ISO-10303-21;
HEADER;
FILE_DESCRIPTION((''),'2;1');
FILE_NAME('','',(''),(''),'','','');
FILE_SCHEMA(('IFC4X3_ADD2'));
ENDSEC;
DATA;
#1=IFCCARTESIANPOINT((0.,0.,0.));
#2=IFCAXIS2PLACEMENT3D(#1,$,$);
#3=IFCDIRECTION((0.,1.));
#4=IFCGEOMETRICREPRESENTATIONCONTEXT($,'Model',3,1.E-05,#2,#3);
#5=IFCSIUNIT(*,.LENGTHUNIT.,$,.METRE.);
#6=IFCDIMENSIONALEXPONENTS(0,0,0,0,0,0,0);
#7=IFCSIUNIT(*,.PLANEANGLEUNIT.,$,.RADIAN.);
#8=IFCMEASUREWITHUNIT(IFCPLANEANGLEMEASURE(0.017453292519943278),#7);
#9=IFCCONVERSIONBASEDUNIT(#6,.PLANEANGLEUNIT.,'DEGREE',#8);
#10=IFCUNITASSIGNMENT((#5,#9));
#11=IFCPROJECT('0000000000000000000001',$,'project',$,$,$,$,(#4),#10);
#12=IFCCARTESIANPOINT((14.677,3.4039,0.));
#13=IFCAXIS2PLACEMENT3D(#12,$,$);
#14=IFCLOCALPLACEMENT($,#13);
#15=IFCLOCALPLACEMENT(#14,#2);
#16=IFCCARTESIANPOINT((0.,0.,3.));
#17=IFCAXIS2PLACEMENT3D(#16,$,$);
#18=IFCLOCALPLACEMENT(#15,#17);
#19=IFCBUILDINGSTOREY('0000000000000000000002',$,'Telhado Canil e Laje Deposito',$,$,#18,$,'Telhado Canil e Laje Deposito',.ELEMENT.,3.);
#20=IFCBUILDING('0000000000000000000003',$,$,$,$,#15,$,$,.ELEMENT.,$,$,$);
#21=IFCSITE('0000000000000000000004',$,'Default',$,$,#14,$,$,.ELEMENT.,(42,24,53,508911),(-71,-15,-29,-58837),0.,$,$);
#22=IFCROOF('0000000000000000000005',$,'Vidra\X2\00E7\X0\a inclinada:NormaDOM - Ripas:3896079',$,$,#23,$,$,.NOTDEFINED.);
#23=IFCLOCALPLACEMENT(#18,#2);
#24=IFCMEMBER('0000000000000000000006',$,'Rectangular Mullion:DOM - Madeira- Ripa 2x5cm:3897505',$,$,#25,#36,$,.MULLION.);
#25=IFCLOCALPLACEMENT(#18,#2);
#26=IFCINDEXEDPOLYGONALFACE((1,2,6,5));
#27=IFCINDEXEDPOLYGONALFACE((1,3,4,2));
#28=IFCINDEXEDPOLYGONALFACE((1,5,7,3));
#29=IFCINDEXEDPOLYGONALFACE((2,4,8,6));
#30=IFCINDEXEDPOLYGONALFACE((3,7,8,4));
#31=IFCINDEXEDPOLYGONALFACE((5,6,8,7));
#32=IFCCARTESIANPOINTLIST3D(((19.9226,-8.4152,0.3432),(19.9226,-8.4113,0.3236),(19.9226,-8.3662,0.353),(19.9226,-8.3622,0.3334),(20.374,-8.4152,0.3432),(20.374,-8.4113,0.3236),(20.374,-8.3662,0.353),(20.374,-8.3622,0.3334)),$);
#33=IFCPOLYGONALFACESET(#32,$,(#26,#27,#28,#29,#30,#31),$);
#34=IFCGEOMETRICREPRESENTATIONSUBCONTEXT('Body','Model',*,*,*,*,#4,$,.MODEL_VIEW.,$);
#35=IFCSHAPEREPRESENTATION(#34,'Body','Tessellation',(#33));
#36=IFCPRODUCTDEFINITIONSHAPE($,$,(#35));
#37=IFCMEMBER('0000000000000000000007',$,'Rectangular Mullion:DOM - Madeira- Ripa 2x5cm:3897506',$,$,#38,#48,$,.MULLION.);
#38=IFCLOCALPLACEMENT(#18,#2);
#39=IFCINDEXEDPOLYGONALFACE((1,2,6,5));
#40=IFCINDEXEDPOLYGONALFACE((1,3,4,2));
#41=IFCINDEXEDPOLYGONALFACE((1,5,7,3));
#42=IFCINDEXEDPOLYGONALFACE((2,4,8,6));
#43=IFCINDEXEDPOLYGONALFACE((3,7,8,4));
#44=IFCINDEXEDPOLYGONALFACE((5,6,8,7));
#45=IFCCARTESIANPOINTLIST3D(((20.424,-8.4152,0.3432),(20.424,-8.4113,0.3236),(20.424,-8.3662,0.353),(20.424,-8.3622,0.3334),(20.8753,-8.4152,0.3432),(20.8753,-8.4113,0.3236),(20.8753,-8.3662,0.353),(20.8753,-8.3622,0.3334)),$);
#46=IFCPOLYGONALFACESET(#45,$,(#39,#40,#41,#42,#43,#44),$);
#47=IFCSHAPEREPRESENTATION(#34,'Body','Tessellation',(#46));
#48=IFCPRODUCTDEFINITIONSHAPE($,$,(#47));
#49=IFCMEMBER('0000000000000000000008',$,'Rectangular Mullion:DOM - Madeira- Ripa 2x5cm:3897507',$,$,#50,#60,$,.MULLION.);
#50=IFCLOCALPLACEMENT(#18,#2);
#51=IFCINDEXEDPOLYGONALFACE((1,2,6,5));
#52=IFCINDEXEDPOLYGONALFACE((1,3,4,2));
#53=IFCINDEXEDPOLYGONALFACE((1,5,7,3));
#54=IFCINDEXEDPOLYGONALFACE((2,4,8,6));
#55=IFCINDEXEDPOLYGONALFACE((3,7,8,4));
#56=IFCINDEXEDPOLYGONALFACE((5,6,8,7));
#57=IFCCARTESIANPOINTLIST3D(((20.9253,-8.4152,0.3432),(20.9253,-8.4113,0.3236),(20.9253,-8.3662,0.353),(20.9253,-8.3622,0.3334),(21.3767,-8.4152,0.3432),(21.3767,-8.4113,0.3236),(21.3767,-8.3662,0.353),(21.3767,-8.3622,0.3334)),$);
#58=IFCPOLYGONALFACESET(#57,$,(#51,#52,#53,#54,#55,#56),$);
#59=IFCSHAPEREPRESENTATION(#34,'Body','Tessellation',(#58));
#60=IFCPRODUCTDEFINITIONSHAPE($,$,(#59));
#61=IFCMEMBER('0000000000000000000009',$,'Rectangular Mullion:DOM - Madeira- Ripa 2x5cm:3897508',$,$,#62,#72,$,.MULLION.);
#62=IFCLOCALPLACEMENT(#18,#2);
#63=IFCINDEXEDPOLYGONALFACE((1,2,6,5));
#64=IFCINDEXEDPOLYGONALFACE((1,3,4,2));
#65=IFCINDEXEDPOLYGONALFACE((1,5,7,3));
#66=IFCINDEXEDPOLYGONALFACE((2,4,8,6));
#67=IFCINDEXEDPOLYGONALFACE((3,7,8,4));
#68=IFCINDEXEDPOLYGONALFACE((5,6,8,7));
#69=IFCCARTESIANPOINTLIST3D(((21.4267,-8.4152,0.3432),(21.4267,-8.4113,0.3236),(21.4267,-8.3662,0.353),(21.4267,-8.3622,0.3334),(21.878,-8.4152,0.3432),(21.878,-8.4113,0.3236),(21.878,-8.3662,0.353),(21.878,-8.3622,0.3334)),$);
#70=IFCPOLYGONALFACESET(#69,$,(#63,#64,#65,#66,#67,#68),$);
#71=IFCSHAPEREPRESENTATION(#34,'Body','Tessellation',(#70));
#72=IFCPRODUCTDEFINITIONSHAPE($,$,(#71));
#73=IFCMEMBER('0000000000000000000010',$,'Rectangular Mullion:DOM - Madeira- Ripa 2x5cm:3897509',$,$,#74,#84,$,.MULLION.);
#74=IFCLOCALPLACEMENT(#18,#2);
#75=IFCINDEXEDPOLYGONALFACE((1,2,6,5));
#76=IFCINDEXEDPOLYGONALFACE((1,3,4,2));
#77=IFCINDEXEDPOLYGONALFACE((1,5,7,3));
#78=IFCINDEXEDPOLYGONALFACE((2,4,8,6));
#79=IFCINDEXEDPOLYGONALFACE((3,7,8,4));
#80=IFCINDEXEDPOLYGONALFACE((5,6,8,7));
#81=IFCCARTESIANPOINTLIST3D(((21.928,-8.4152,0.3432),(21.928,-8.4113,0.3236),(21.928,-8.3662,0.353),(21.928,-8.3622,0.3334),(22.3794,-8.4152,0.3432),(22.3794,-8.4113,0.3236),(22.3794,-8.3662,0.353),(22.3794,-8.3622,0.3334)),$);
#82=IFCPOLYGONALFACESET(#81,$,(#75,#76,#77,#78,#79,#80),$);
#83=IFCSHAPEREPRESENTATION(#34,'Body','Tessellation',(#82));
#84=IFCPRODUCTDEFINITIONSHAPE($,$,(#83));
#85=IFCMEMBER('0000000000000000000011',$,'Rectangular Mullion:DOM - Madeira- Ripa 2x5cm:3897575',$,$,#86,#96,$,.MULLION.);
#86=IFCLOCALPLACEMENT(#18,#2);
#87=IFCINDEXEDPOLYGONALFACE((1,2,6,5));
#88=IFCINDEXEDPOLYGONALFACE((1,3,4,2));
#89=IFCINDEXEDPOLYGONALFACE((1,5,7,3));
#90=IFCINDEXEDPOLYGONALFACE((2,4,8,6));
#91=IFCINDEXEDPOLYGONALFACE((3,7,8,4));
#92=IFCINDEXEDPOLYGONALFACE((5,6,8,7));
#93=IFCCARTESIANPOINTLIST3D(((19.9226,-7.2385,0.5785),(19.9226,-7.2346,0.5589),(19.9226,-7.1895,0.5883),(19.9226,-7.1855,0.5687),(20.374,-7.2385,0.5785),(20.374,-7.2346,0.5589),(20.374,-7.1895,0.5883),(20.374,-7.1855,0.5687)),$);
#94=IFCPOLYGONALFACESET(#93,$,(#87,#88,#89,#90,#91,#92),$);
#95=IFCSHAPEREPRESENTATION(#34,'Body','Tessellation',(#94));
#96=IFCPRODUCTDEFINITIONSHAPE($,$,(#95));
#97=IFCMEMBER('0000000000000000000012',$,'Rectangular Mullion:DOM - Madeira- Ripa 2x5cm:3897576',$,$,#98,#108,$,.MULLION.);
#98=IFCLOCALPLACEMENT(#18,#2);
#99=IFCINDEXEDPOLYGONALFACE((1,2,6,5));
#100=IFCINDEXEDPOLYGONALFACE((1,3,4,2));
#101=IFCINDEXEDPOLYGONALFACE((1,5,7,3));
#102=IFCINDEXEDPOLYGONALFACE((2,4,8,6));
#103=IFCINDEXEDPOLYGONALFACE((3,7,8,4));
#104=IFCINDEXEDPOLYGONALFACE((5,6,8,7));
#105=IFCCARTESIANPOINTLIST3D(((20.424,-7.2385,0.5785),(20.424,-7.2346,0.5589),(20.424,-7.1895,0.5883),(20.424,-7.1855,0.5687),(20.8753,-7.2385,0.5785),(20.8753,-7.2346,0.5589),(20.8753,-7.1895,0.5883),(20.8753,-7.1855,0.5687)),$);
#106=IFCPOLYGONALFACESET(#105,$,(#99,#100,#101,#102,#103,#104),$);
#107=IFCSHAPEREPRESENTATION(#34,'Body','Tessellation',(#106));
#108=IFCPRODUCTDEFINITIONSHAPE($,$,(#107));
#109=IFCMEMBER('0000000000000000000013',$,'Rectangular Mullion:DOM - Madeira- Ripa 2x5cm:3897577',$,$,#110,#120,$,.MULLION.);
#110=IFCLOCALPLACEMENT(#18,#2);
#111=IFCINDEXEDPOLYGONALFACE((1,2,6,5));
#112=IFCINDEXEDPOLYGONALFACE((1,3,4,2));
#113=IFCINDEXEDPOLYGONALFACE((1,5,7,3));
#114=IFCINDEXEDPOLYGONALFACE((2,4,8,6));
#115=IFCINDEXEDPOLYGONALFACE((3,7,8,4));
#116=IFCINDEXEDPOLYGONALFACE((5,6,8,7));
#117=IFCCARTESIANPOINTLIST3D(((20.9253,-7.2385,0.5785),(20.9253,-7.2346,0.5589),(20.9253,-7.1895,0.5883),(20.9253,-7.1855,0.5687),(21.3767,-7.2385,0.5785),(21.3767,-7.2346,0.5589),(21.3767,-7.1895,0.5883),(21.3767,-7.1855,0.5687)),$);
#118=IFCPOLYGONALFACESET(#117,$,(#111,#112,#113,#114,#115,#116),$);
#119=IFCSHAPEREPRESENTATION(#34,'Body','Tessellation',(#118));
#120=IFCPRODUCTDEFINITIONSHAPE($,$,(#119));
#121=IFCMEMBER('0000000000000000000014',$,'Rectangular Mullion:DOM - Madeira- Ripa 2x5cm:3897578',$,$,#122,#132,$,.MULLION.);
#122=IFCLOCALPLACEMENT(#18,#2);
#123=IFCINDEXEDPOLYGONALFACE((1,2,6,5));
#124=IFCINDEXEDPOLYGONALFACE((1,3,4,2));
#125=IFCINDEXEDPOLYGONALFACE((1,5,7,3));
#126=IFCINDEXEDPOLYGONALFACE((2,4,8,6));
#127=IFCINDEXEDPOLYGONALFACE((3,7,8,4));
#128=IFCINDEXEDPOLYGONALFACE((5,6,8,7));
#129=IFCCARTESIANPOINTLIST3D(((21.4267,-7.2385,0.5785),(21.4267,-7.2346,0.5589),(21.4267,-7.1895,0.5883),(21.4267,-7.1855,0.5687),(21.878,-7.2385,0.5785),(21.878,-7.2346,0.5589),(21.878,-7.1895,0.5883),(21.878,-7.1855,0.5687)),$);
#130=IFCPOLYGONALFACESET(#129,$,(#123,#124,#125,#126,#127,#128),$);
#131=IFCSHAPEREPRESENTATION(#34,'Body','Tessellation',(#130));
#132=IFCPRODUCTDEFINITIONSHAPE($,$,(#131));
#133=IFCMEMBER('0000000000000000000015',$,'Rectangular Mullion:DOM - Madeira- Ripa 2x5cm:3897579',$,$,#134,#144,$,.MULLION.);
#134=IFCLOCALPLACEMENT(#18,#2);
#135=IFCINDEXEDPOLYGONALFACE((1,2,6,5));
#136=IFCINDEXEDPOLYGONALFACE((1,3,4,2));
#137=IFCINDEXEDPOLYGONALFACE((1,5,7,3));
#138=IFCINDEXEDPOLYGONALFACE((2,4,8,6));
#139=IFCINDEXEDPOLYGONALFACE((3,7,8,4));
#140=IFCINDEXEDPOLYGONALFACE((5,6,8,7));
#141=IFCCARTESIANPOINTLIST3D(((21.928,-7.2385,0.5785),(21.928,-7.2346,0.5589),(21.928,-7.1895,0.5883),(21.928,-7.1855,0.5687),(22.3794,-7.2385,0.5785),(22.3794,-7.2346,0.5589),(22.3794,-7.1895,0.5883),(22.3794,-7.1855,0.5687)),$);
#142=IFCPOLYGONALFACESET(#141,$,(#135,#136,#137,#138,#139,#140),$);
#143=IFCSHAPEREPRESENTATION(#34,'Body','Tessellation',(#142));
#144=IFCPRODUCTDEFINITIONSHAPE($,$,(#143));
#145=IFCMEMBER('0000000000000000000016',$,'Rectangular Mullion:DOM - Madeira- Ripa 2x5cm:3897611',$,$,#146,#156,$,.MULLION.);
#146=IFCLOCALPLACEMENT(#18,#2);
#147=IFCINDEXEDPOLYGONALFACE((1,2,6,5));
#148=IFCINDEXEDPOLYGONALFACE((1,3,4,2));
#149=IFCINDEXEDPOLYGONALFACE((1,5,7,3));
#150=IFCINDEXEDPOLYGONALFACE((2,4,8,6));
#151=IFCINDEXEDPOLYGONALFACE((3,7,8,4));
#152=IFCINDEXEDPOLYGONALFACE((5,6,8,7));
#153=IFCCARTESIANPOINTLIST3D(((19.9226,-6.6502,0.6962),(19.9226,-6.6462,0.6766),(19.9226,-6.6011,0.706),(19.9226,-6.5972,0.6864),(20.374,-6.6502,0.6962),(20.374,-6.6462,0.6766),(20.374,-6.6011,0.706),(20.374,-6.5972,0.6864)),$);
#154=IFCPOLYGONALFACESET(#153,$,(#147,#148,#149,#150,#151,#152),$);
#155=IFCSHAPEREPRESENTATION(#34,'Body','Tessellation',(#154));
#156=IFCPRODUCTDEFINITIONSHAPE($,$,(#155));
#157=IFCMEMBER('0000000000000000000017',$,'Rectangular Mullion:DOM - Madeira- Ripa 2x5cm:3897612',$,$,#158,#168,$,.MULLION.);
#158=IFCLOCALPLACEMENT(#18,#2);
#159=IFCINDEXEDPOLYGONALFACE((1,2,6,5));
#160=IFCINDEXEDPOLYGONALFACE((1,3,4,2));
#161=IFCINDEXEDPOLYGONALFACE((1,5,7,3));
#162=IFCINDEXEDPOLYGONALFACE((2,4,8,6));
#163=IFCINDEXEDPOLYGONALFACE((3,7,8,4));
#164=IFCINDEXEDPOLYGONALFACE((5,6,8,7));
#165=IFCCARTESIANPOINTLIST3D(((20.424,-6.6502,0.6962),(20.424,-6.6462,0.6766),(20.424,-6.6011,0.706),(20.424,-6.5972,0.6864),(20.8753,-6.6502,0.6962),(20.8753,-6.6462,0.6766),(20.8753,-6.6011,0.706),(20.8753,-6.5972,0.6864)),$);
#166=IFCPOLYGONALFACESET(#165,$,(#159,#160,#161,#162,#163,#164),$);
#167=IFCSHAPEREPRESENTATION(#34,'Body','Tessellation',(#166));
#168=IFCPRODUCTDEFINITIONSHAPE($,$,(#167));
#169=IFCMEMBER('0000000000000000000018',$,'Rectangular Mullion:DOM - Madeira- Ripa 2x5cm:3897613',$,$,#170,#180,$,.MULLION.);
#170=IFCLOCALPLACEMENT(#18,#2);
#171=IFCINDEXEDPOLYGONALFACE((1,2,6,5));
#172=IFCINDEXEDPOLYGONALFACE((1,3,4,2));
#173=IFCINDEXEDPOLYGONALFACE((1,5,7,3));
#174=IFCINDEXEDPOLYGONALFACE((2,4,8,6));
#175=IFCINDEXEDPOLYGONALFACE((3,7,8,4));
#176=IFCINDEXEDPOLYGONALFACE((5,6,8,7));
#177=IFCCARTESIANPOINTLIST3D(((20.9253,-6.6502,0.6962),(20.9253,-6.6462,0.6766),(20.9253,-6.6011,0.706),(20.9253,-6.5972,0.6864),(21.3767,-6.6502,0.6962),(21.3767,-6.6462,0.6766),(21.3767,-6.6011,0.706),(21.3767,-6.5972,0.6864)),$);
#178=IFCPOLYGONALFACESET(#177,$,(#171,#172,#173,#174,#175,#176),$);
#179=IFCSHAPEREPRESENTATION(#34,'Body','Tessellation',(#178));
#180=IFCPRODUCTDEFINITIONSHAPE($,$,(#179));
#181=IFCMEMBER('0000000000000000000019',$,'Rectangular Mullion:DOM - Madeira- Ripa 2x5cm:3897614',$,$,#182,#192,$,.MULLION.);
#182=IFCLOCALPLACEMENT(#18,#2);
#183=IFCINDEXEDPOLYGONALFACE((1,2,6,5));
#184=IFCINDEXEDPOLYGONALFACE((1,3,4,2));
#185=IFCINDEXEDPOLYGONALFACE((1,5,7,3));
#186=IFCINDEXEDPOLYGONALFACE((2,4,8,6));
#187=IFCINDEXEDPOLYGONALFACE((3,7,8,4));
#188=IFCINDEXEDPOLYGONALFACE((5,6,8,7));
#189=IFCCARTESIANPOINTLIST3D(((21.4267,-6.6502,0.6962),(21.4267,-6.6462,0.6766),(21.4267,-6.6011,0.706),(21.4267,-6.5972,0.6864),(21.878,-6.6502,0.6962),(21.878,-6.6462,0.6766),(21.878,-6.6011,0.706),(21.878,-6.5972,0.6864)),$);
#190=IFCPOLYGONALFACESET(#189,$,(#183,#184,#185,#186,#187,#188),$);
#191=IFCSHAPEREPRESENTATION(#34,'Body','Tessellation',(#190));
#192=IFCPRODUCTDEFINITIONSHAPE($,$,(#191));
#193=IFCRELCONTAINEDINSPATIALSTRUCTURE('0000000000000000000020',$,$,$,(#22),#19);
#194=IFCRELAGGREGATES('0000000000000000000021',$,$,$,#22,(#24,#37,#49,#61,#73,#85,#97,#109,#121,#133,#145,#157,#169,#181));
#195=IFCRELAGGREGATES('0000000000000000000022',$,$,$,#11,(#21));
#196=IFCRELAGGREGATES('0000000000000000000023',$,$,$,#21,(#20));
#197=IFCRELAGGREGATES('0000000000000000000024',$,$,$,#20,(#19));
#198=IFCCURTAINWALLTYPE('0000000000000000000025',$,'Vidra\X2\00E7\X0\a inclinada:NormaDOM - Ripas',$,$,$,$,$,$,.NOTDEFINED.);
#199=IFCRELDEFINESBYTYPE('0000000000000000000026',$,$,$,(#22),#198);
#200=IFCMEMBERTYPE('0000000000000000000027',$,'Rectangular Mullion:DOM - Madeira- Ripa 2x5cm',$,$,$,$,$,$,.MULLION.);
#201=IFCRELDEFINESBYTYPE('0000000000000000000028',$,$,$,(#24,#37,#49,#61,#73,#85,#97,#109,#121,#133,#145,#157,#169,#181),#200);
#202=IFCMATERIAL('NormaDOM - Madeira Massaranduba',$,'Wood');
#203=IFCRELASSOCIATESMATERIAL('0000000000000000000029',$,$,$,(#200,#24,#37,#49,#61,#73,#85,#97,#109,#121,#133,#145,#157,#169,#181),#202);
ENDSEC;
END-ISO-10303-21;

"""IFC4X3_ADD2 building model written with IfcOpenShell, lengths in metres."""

from ifc_helpers import new_model, entity, si_unit, converted_unit, direction, frame, origin, origin_2d_with_axis, place, context, subcontext, project, spatial, rectangle, extrude, source, transform, mapped, material, material_profile, profile_set, profile_usage, type_object, type_shapes, element, aggregate, save


model = new_model("IFC4X3_ADD2")

# Units and contexts
model_context = context("Model", 3, precision=1e-05, world=origin(), true_north=direction((0.0, 1.0)))
body_context = subcontext(model_context, "Body", "Model", "MODEL_VIEW")
ifc_project = project(units=[si_unit("LENGTHUNIT", "METRE"), converted_unit("PLANEANGLEUNIT", "DEGREE", entity("IfcPlaneAngleMeasure", 0.017453292519943278), si_unit("PLANEANGLEUNIT", "RADIAN"), dimensions=[0, 0, 0, 0, 0, 0, 0])], contexts=[model_context])

# Site, building, storey
site_placement = place(None, frame((14.677, 3.4039, 0.0)))
site = spatial("IfcSite", under=ifc_project, at=site_placement, Name="Default", CompositionType="ELEMENT", RefLatitude=(42, 24, 53, 508911), RefLongitude=(-71, -15, -29, -58837), RefElevation=0.0)
building_placement = place(site_placement, origin())
building = spatial("IfcBuilding", under=site, at=building_placement, CompositionType="ELEMENT")
storey_placement = place(building_placement, frame((0.0, 0.0, 3.0)))
storey = spatial("IfcBuildingStorey", under=building, at=storey_placement, Name="Telhado Canil e Laje Deposito", LongName="Telhado Canil e Laje Deposito", CompositionType="ELEMENT", Elevation=3.0)

# Shared definitions
ifc_material = material(Name="NormaDOM - Madeira Massaranduba", Category="Wood")

# Roof, members
curtain_wall_type_1 = type_object("IfcCurtainWallType", Name="Vidraça inclinada:NormaDOM - Ripas", PredefinedType="NOTDEFINED")
roof_1_placement = place(storey_placement, frame((0.0, 0.0, -3.0)))
roof_1 = element("IfcRoof", 1, at=roof_1_placement, inside=storey, type_object=curtain_wall_type_1, Name="Vidraça inclinada:NormaDOM - Ripas:3896079", PredefinedType="NOTDEFINED")
ifc_material_profile_1 = material_profile(ifc_material, rectangle(XDim=0.05, YDim=0.02, at=origin_2d_with_axis()), Name="DOM - Madeira- Ripa 2x5cm")
ifc_profile_set_1 = profile_set([ifc_material_profile_1], Name="DOM - Madeira- Ripa 2x5cm")
ifc_profile_usage_1 = profile_usage(ifc_profile_set_1)
member_type_1 = type_object("IfcMemberType", Name="Rectangular Mullion:DOM - Madeira- Ripa 2x5cm", PredefinedType="MULLION", material=ifc_profile_set_1)
shared_shape_1 = source(origin(), body_context, "Body", "SweptSolid", [
    extrude(rectangle(XDim=0.05, YDim=0.02, at=origin_2d_with_axis()), frame((0.025, 0.01, -0.4514), z_axis=(0.0, 0.0, 1.0), x_axis=(-1.0, 0.0, 0.0)), (0.0, 0.0, 1.0), 0.4514),
])
type_shapes(member_type_1, [shared_shape_1])
member_1_placement = place(roof_1_placement, frame((19.9226, -8.4152, 3.3432), z_axis=(-1.0, 0.0, 0.0), x_axis=(0.0, 0.980581, 0.196116)))
member_1 = element("IfcMember", 2, at=member_1_placement, type_object=member_type_1, material=ifc_profile_usage_1, Name="Rectangular Mullion:DOM - Madeira- Ripa 2x5cm:3897505", PredefinedType="MULLION", context=body_context, shape_type="MappedRepresentation", body=[
    mapped(shared_shape_1, transform((0.0, 0.0, 0.0), scale=1.0)),
])
member_2_placement = place(roof_1_placement, frame((20.424, -8.4152, 3.3432), z_axis=(-1.0, 0.0, 0.0), x_axis=(0.0, 0.980581, 0.196116)))
member_2 = element("IfcMember", 3, at=member_2_placement, type_object=member_type_1, material=ifc_profile_usage_1, Name="Rectangular Mullion:DOM - Madeira- Ripa 2x5cm:3897506", PredefinedType="MULLION", context=body_context, shape_type="MappedRepresentation", body=[
    mapped(shared_shape_1, transform((0.0, 0.0, 0.0), scale=1.0)),
])
member_3_placement = place(roof_1_placement, frame((20.9253, -8.4152, 3.3432), z_axis=(-1.0, 0.0, 0.0), x_axis=(0.0, 0.980581, 0.196116)))
member_3 = element("IfcMember", 4, at=member_3_placement, type_object=member_type_1, material=ifc_profile_usage_1, Name="Rectangular Mullion:DOM - Madeira- Ripa 2x5cm:3897507", PredefinedType="MULLION", context=body_context, shape_type="MappedRepresentation", body=[
    mapped(shared_shape_1, transform((0.0, 0.0, 0.0), scale=1.0)),
])
member_4_placement = place(roof_1_placement, frame((21.4267, -8.4152, 3.3432), z_axis=(-1.0, 0.0, 0.0), x_axis=(0.0, 0.980581, 0.196116)))
member_4 = element("IfcMember", 5, at=member_4_placement, type_object=member_type_1, material=ifc_profile_usage_1, Name="Rectangular Mullion:DOM - Madeira- Ripa 2x5cm:3897508", PredefinedType="MULLION", context=body_context, shape_type="MappedRepresentation", body=[
    mapped(shared_shape_1, transform((0.0, 0.0, 0.0), scale=1.0)),
])
member_5_placement = place(roof_1_placement, frame((21.928, -8.4152, 3.3432), z_axis=(-1.0, 0.0, 0.0), x_axis=(0.0, 0.980581, 0.196116)))
member_5 = element("IfcMember", 6, at=member_5_placement, type_object=member_type_1, material=ifc_profile_usage_1, Name="Rectangular Mullion:DOM - Madeira- Ripa 2x5cm:3897509", PredefinedType="MULLION", context=body_context, shape_type="MappedRepresentation", body=[
    mapped(shared_shape_1, transform((0.0, 0.0, 0.0), scale=1.0)),
])
member_6_placement = place(roof_1_placement, frame((19.9226, -7.2385, 3.5785), z_axis=(-1.0, 0.0, 0.0), x_axis=(0.0, 0.980581, 0.196116)))
member_6 = element("IfcMember", 7, at=member_6_placement, type_object=member_type_1, material=ifc_profile_usage_1, Name="Rectangular Mullion:DOM - Madeira- Ripa 2x5cm:3897575", PredefinedType="MULLION", context=body_context, shape_type="MappedRepresentation", body=[
    mapped(shared_shape_1, transform((0.0, 0.0, 0.0), scale=1.0)),
])
member_7_placement = place(roof_1_placement, frame((20.424, -7.2385, 3.5785), z_axis=(-1.0, 0.0, 0.0), x_axis=(0.0, 0.980581, 0.196116)))
member_7 = element("IfcMember", 8, at=member_7_placement, type_object=member_type_1, material=ifc_profile_usage_1, Name="Rectangular Mullion:DOM - Madeira- Ripa 2x5cm:3897576", PredefinedType="MULLION", context=body_context, shape_type="MappedRepresentation", body=[
    mapped(shared_shape_1, transform((0.0, 0.0, 0.0), scale=1.0)),
])
member_8_placement = place(roof_1_placement, frame((20.9253, -7.2385, 3.5785), z_axis=(-1.0, 0.0, 0.0), x_axis=(0.0, 0.980581, 0.196116)))
member_8 = element("IfcMember", 9, at=member_8_placement, type_object=member_type_1, material=ifc_profile_usage_1, Name="Rectangular Mullion:DOM - Madeira- Ripa 2x5cm:3897577", PredefinedType="MULLION", context=body_context, shape_type="MappedRepresentation", body=[
    mapped(shared_shape_1, transform((0.0, 0.0, 0.0), scale=1.0)),
])
member_9_placement = place(roof_1_placement, frame((21.4267, -7.2385, 3.5785), z_axis=(-1.0, 0.0, 0.0), x_axis=(0.0, 0.980581, 0.196116)))
member_9 = element("IfcMember", 10, at=member_9_placement, type_object=member_type_1, material=ifc_profile_usage_1, Name="Rectangular Mullion:DOM - Madeira- Ripa 2x5cm:3897578", PredefinedType="MULLION", context=body_context, shape_type="MappedRepresentation", body=[
    mapped(shared_shape_1, transform((0.0, 0.0, 0.0), scale=1.0)),
])
member_10_placement = place(roof_1_placement, frame((21.928, -7.2385, 3.5785), z_axis=(-1.0, 0.0, 0.0), x_axis=(0.0, 0.980581, 0.196116)))
member_10 = element("IfcMember", 11, at=member_10_placement, type_object=member_type_1, material=ifc_profile_usage_1, Name="Rectangular Mullion:DOM - Madeira- Ripa 2x5cm:3897579", PredefinedType="MULLION", context=body_context, shape_type="MappedRepresentation", body=[
    mapped(shared_shape_1, transform((0.0, 0.0, 0.0), scale=1.0)),
])
member_11_placement = place(roof_1_placement, frame((19.9226, -6.6502, 3.6962), z_axis=(-1.0, 0.0, 0.0), x_axis=(0.0, 0.980581, 0.196116)))
member_11 = element("IfcMember", 12, at=member_11_placement, type_object=member_type_1, material=ifc_profile_usage_1, Name="Rectangular Mullion:DOM - Madeira- Ripa 2x5cm:3897611", PredefinedType="MULLION", context=body_context, shape_type="MappedRepresentation", body=[
    mapped(shared_shape_1, transform((0.0, 0.0, 0.0), scale=1.0)),
])
member_12_placement = place(roof_1_placement, frame((20.424, -6.6502, 3.6962), z_axis=(-1.0, 0.0, 0.0), x_axis=(0.0, 0.980581, 0.196116)))
member_12 = element("IfcMember", 13, at=member_12_placement, type_object=member_type_1, material=ifc_profile_usage_1, Name="Rectangular Mullion:DOM - Madeira- Ripa 2x5cm:3897612", PredefinedType="MULLION", context=body_context, shape_type="MappedRepresentation", body=[
    mapped(shared_shape_1, transform((0.0, 0.0, 0.0), scale=1.0)),
])
member_13_placement = place(roof_1_placement, frame((20.9253, -6.6502, 3.6962), z_axis=(-1.0, 0.0, 0.0), x_axis=(0.0, 0.980581, 0.196116)))
member_13 = element("IfcMember", 14, at=member_13_placement, type_object=member_type_1, material=ifc_profile_usage_1, Name="Rectangular Mullion:DOM - Madeira- Ripa 2x5cm:3897613", PredefinedType="MULLION", context=body_context, shape_type="MappedRepresentation", body=[
    mapped(shared_shape_1, transform((0.0, 0.0, 0.0), scale=1.0)),
])
member_14_placement = place(roof_1_placement, frame((21.4267, -6.6502, 3.6962), z_axis=(-1.0, 0.0, 0.0), x_axis=(0.0, 0.980581, 0.196116)))
member_14 = element("IfcMember", 15, at=member_14_placement, type_object=member_type_1, material=ifc_profile_usage_1, Name="Rectangular Mullion:DOM - Madeira- Ripa 2x5cm:3897614", PredefinedType="MULLION", context=body_context, shape_type="MappedRepresentation", body=[
    mapped(shared_shape_1, transform((0.0, 0.0, 0.0), scale=1.0)),
])
aggregate(roof_1, [member_1, member_2, member_3, member_4, member_5, member_6, member_7, member_8, member_9, member_10, member_11, member_12, member_13, member_14])

save(model, "model.ifc")
